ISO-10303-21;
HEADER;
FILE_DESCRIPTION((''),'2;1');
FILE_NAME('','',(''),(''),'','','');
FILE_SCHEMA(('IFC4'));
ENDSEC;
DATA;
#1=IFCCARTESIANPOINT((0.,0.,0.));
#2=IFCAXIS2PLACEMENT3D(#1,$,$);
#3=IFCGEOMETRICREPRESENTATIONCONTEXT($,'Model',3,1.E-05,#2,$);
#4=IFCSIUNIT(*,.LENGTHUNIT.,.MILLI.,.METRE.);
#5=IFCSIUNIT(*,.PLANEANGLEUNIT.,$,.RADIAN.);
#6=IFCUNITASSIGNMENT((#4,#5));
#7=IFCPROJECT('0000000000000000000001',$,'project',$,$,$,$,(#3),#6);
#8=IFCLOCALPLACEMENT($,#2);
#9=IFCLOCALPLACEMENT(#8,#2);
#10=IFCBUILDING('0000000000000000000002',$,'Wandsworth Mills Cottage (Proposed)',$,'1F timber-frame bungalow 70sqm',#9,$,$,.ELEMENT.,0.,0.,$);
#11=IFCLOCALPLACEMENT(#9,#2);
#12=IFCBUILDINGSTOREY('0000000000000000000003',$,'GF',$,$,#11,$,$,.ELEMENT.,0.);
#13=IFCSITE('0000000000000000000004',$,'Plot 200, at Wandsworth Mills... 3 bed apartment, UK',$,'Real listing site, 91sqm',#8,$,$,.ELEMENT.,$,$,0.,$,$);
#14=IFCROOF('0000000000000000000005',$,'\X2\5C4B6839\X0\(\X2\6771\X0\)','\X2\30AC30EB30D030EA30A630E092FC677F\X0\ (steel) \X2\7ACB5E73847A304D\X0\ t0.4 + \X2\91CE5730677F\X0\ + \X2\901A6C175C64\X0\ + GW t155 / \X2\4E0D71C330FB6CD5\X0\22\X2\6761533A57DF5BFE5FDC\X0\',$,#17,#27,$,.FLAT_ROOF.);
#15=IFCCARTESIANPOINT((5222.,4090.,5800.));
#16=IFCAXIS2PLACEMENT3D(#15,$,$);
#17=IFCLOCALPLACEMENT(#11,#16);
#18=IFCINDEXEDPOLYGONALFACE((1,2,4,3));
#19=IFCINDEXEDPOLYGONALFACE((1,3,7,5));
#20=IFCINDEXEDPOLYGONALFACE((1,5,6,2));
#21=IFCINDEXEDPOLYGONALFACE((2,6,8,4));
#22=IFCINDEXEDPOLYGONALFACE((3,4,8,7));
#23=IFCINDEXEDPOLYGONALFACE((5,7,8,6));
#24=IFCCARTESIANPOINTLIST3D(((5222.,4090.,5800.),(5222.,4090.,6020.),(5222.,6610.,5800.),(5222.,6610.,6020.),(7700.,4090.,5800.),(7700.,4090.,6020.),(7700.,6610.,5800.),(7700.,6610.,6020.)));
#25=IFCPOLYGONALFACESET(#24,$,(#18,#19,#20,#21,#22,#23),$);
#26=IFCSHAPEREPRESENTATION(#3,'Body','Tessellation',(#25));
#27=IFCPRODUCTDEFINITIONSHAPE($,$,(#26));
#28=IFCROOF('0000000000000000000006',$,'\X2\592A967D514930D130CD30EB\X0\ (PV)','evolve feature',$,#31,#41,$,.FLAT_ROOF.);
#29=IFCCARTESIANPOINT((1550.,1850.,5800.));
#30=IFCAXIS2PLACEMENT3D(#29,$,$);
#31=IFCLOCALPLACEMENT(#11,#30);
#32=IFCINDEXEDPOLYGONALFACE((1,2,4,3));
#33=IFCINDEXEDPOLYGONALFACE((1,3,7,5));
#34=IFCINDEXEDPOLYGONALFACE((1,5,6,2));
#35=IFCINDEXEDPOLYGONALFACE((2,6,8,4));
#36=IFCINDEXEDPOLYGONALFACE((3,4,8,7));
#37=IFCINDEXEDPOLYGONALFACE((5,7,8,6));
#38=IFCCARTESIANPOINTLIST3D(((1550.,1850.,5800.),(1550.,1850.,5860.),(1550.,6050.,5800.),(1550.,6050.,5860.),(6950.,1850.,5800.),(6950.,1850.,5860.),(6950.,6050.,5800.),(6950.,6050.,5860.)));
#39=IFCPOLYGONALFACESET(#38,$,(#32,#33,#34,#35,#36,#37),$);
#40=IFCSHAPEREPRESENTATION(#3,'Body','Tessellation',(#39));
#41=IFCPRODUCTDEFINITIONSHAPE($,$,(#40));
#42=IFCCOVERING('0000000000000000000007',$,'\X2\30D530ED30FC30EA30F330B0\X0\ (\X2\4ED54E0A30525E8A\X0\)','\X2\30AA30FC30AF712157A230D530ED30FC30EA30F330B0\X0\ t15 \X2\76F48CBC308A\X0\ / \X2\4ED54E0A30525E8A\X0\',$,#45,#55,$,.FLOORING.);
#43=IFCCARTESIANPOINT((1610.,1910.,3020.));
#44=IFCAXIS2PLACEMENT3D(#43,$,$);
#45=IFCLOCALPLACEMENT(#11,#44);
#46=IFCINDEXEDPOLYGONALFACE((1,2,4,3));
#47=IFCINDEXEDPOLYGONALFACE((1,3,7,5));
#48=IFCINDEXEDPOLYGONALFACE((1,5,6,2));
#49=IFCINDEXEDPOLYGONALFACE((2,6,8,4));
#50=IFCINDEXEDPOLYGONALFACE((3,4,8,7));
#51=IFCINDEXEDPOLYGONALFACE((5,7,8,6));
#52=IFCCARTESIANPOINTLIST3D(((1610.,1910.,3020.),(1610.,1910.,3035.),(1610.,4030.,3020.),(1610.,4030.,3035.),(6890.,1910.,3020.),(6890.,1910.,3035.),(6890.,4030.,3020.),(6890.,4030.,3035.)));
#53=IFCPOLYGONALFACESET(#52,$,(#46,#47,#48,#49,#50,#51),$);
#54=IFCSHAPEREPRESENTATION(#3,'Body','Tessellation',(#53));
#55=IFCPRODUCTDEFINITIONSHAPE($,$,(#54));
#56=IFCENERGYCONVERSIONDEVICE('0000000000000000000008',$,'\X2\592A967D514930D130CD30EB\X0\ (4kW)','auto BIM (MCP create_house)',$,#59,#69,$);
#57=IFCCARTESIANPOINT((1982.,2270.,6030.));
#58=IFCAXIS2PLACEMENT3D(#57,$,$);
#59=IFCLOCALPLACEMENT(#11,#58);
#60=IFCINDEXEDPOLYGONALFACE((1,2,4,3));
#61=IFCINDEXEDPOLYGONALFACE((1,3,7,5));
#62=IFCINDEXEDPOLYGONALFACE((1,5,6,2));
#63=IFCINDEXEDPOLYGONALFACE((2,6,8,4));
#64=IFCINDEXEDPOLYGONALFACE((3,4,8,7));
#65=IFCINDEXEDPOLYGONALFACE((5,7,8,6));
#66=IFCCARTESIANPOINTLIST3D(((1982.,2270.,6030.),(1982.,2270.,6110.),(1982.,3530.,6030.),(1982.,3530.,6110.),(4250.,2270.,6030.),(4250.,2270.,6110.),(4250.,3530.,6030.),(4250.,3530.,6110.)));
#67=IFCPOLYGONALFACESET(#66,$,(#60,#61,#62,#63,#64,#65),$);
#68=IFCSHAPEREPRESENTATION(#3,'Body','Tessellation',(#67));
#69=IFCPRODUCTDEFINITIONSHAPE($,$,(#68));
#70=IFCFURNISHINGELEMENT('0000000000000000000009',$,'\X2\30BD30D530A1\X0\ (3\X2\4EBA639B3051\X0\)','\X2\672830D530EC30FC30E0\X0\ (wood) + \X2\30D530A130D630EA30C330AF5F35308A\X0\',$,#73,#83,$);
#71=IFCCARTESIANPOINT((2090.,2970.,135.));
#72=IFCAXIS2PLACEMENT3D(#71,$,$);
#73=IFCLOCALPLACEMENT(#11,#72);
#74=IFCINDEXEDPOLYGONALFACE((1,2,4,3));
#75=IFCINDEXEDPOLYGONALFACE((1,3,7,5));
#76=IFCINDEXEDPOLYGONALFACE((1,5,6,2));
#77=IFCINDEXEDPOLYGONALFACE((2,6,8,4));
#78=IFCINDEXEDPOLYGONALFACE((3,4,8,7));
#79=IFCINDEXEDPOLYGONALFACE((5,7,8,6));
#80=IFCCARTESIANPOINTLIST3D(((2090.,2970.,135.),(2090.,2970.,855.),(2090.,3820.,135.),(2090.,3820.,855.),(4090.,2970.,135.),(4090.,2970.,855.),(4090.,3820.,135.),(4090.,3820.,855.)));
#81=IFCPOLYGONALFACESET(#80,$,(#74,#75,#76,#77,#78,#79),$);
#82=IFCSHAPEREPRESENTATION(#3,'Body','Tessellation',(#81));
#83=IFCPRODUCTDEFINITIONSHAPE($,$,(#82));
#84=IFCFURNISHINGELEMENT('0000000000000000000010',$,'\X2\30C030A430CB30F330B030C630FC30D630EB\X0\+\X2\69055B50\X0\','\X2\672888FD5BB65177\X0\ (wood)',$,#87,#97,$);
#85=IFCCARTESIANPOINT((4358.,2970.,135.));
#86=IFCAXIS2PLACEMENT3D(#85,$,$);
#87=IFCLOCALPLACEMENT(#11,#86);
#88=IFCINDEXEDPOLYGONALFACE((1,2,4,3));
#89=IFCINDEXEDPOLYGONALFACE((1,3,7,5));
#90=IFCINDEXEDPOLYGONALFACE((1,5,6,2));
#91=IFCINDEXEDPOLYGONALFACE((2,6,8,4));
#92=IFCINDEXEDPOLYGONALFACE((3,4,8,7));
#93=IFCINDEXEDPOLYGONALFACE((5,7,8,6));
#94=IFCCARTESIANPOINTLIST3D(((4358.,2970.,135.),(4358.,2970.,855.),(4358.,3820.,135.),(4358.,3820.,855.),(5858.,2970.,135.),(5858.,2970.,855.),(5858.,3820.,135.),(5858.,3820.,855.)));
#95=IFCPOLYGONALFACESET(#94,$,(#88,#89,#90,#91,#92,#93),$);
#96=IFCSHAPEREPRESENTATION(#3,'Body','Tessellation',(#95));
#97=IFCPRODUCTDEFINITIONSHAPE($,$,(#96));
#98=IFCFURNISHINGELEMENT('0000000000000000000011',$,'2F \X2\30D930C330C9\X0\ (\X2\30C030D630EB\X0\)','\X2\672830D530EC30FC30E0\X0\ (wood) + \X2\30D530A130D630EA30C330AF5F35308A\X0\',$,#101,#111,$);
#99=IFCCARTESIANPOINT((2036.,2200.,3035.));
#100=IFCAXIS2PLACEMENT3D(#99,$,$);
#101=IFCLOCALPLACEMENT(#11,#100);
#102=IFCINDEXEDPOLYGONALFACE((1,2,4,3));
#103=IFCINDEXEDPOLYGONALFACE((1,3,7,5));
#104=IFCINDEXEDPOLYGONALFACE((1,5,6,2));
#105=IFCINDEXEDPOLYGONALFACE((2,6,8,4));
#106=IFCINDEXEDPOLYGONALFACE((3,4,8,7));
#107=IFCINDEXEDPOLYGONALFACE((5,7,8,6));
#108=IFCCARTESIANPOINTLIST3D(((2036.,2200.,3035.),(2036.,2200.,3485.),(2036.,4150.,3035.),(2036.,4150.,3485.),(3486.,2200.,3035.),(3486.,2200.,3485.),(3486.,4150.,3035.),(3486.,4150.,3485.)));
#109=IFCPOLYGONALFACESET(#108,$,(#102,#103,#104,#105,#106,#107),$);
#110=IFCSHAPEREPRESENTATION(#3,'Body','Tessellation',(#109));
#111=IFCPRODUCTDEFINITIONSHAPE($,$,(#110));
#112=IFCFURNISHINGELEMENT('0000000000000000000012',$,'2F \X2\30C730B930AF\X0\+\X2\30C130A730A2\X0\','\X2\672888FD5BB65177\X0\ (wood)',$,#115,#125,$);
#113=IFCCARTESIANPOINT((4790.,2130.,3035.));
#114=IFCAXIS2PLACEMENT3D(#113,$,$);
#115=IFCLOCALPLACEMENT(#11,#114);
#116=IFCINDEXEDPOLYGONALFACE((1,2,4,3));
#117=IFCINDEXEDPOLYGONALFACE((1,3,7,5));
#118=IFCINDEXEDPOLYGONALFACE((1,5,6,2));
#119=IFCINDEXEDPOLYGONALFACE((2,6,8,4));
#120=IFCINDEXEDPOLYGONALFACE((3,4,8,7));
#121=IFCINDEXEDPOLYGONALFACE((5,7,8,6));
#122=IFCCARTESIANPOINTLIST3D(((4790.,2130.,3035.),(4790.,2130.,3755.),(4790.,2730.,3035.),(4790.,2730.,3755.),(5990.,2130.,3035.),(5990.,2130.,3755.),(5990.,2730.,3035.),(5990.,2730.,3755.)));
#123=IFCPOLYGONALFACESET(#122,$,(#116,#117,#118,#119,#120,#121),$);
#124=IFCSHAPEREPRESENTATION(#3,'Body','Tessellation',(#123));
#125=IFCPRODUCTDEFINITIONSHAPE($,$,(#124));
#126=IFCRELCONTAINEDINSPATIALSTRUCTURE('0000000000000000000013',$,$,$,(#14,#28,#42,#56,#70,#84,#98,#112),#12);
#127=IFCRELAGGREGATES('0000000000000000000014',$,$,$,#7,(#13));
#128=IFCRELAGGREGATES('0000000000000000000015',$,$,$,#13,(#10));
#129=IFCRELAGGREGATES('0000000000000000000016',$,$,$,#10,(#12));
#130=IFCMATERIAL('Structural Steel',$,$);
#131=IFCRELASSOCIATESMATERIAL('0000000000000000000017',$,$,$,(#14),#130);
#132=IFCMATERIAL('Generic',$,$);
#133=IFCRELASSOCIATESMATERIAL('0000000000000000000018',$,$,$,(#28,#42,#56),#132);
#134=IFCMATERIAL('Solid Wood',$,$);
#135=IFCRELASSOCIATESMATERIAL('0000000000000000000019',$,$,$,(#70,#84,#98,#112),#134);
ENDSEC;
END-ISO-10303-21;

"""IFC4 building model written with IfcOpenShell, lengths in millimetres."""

from ifc_helpers import new_model, si_unit, frame, frame_2d, origin, place, context, project, spatial, rectangle, extrude, material, element, save


model = new_model("IFC4")

# Units and contexts
model_context = context("Model", 3, precision=1e-05, world=origin())
ifc_project = project(units=[si_unit("LENGTHUNIT", "METRE", prefix="MILLI"), si_unit("PLANEANGLEUNIT", "RADIAN")], contexts=[model_context])

# Site, building, storey
site_placement = place(None, origin())
site = spatial("IfcSite", under=ifc_project, at=site_placement, Name="Plot 200, at Wandsworth Mills... 3 bed apartment, UK", ObjectType="Real listing site, 91sqm", CompositionType="ELEMENT", RefElevation=0.0)
building_placement = place(site_placement, origin())
building = spatial("IfcBuilding", under=site, at=building_placement, Name="Wandsworth Mills Cottage (Proposed)", ObjectType="1F timber-frame bungalow 70sqm", CompositionType="ELEMENT", ElevationOfRefHeight=0.0, ElevationOfTerrain=0.0)
storey_placement = place(building_placement, origin())
storey = spatial("IfcBuildingStorey", under=building, at=storey_placement, Name="GF", CompositionType="ELEMENT", Elevation=0.0)

# Shared definitions
ifc_material_1 = material(Name="Solid Wood")

# Shared definitions
ifc_material_2 = material(Name="Generic")

# Roofs
ifc_material_3 = material(Name="Structural Steel")
roof_1_placement = place(storey_placement, frame((5222.0, 4090.0, 5800.0)))
element("IfcRoof", 1, at=roof_1_placement, inside=storey, material=ifc_material_3, Name="屋根(東)", Description="ガルバリウム鋼板 (steel) 立平葺き t0.4 + 野地板 + 通気層 + GW t155 / 不燃・法22条区域対応", PredefinedType="FLAT_ROOF", context=model_context, shape_type="SweptSolid", body=[
    extrude(rectangle(XDim=2478.0, YDim=2520.0, at=frame_2d((1239.0, 1260.0))), frame((5222.0, 4090.0, 5800.0)), (0.0, 0.0, 1.0), 220.0),
])
roof_2_placement = place(storey_placement, frame((1550.0, 1850.0, 5800.0)))
element("IfcRoof", 2, at=roof_2_placement, inside=storey, material=ifc_material_2, Name="太陽光パネル (PV)", Description="evolve feature", PredefinedType="FLAT_ROOF", context=model_context, shape_type="SweptSolid", body=[
    extrude(rectangle(XDim=5400.0, YDim=4200.0, at=frame_2d((2700.0, 2100.0))), frame((1550.0, 1850.0, 5800.0)), (0.0, 0.0, 1.0), 60.0),
])

# Covering
covering_placement = place(storey_placement, frame((1610.0, 1910.0, 3020.0)))
element("IfcCovering", 3, at=covering_placement, inside=storey, material=ifc_material_2, Name="フローリング (仕上げ床)", Description="オーク無垢フローリング t15 直貼り / 仕上げ床", PredefinedType="FLOORING", context=model_context, shape_type="SweptSolid", body=[
    extrude(rectangle(XDim=5280.0, YDim=2120.0, at=frame_2d((2640.0, 1060.0))), frame((1610.0, 1910.0, 3020.0)), (0.0, 0.0, 1.0), 15.0),
])

# Energy conversion device
energy_conversion_device_placement = place(storey_placement, frame((1982.0, 2270.0, 6030.0)))
element("IfcEnergyConversionDevice", 4, at=energy_conversion_device_placement, inside=storey, material=ifc_material_2, Name="太陽光パネル (4kW)", Description="auto BIM (MCP create_house)", context=model_context, shape_type="SweptSolid", body=[
    extrude(rectangle(XDim=2268.0, YDim=1260.0, at=frame_2d((1134.0, 630.0))), frame((1982.0, 2270.0, 6030.0)), (0.0, 0.0, 1.0), 80.0),
])

# Furnishing elements
furnishing_1_placement = place(storey_placement, frame((2090.0, 2970.0, 135.0)))
element("IfcFurnishingElement", 5, at=furnishing_1_placement, inside=storey, material=ifc_material_1, Name="ソファ (3人掛け)", Description="木フレーム (wood) + ファブリック張り", context=model_context, shape_type="SweptSolid", body=[
    extrude(rectangle(XDim=2000.0, YDim=850.0, at=frame_2d((1000.0, 425.0))), frame((2090.0, 2970.0, 135.0)), (0.0, 0.0, 1.0), 720.0),
])
furnishing_2_placement = place(storey_placement, frame((4358.0, 2970.0, 135.0)))
element("IfcFurnishingElement", 6, at=furnishing_2_placement, inside=storey, material=ifc_material_1, Name="ダイニングテーブル+椅子", Description="木製家具 (wood)", context=model_context, shape_type="SweptSolid", body=[
    extrude(rectangle(XDim=1500.0, YDim=850.0, at=frame_2d((750.0, 425.0))), frame((4358.0, 2970.0, 135.0)), (0.0, 0.0, 1.0), 720.0),
])
furnishing_3_placement = place(storey_placement, frame((2036.0, 2200.0, 3035.0)))
element("IfcFurnishingElement", 7, at=furnishing_3_placement, inside=storey, material=ifc_material_1, Name="2F ベッド (ダブル)", Description="木フレーム (wood) + ファブリック張り", context=model_context, shape_type="SweptSolid", body=[
    extrude(rectangle(XDim=1450.0, YDim=1950.0, at=frame_2d((725.0, 975.0))), frame((2036.0, 2200.0, 3035.0)), (0.0, 0.0, 1.0), 450.0),
])
furnishing_4_placement = place(storey_placement, frame((4790.0, 2130.0, 3035.0)))
element("IfcFurnishingElement", 8, at=furnishing_4_placement, inside=storey, material=ifc_material_1, Name="2F デスク+チェア", Description="木製家具 (wood)", context=model_context, shape_type="SweptSolid", body=[
    extrude(rectangle(XDim=1200.0, YDim=600.0, at=frame_2d((600.0, 300.0))), frame((4790.0, 2130.0, 3035.0)), (0.0, 0.0, 1.0), 720.0),
])

save(model, "model.ifc")
